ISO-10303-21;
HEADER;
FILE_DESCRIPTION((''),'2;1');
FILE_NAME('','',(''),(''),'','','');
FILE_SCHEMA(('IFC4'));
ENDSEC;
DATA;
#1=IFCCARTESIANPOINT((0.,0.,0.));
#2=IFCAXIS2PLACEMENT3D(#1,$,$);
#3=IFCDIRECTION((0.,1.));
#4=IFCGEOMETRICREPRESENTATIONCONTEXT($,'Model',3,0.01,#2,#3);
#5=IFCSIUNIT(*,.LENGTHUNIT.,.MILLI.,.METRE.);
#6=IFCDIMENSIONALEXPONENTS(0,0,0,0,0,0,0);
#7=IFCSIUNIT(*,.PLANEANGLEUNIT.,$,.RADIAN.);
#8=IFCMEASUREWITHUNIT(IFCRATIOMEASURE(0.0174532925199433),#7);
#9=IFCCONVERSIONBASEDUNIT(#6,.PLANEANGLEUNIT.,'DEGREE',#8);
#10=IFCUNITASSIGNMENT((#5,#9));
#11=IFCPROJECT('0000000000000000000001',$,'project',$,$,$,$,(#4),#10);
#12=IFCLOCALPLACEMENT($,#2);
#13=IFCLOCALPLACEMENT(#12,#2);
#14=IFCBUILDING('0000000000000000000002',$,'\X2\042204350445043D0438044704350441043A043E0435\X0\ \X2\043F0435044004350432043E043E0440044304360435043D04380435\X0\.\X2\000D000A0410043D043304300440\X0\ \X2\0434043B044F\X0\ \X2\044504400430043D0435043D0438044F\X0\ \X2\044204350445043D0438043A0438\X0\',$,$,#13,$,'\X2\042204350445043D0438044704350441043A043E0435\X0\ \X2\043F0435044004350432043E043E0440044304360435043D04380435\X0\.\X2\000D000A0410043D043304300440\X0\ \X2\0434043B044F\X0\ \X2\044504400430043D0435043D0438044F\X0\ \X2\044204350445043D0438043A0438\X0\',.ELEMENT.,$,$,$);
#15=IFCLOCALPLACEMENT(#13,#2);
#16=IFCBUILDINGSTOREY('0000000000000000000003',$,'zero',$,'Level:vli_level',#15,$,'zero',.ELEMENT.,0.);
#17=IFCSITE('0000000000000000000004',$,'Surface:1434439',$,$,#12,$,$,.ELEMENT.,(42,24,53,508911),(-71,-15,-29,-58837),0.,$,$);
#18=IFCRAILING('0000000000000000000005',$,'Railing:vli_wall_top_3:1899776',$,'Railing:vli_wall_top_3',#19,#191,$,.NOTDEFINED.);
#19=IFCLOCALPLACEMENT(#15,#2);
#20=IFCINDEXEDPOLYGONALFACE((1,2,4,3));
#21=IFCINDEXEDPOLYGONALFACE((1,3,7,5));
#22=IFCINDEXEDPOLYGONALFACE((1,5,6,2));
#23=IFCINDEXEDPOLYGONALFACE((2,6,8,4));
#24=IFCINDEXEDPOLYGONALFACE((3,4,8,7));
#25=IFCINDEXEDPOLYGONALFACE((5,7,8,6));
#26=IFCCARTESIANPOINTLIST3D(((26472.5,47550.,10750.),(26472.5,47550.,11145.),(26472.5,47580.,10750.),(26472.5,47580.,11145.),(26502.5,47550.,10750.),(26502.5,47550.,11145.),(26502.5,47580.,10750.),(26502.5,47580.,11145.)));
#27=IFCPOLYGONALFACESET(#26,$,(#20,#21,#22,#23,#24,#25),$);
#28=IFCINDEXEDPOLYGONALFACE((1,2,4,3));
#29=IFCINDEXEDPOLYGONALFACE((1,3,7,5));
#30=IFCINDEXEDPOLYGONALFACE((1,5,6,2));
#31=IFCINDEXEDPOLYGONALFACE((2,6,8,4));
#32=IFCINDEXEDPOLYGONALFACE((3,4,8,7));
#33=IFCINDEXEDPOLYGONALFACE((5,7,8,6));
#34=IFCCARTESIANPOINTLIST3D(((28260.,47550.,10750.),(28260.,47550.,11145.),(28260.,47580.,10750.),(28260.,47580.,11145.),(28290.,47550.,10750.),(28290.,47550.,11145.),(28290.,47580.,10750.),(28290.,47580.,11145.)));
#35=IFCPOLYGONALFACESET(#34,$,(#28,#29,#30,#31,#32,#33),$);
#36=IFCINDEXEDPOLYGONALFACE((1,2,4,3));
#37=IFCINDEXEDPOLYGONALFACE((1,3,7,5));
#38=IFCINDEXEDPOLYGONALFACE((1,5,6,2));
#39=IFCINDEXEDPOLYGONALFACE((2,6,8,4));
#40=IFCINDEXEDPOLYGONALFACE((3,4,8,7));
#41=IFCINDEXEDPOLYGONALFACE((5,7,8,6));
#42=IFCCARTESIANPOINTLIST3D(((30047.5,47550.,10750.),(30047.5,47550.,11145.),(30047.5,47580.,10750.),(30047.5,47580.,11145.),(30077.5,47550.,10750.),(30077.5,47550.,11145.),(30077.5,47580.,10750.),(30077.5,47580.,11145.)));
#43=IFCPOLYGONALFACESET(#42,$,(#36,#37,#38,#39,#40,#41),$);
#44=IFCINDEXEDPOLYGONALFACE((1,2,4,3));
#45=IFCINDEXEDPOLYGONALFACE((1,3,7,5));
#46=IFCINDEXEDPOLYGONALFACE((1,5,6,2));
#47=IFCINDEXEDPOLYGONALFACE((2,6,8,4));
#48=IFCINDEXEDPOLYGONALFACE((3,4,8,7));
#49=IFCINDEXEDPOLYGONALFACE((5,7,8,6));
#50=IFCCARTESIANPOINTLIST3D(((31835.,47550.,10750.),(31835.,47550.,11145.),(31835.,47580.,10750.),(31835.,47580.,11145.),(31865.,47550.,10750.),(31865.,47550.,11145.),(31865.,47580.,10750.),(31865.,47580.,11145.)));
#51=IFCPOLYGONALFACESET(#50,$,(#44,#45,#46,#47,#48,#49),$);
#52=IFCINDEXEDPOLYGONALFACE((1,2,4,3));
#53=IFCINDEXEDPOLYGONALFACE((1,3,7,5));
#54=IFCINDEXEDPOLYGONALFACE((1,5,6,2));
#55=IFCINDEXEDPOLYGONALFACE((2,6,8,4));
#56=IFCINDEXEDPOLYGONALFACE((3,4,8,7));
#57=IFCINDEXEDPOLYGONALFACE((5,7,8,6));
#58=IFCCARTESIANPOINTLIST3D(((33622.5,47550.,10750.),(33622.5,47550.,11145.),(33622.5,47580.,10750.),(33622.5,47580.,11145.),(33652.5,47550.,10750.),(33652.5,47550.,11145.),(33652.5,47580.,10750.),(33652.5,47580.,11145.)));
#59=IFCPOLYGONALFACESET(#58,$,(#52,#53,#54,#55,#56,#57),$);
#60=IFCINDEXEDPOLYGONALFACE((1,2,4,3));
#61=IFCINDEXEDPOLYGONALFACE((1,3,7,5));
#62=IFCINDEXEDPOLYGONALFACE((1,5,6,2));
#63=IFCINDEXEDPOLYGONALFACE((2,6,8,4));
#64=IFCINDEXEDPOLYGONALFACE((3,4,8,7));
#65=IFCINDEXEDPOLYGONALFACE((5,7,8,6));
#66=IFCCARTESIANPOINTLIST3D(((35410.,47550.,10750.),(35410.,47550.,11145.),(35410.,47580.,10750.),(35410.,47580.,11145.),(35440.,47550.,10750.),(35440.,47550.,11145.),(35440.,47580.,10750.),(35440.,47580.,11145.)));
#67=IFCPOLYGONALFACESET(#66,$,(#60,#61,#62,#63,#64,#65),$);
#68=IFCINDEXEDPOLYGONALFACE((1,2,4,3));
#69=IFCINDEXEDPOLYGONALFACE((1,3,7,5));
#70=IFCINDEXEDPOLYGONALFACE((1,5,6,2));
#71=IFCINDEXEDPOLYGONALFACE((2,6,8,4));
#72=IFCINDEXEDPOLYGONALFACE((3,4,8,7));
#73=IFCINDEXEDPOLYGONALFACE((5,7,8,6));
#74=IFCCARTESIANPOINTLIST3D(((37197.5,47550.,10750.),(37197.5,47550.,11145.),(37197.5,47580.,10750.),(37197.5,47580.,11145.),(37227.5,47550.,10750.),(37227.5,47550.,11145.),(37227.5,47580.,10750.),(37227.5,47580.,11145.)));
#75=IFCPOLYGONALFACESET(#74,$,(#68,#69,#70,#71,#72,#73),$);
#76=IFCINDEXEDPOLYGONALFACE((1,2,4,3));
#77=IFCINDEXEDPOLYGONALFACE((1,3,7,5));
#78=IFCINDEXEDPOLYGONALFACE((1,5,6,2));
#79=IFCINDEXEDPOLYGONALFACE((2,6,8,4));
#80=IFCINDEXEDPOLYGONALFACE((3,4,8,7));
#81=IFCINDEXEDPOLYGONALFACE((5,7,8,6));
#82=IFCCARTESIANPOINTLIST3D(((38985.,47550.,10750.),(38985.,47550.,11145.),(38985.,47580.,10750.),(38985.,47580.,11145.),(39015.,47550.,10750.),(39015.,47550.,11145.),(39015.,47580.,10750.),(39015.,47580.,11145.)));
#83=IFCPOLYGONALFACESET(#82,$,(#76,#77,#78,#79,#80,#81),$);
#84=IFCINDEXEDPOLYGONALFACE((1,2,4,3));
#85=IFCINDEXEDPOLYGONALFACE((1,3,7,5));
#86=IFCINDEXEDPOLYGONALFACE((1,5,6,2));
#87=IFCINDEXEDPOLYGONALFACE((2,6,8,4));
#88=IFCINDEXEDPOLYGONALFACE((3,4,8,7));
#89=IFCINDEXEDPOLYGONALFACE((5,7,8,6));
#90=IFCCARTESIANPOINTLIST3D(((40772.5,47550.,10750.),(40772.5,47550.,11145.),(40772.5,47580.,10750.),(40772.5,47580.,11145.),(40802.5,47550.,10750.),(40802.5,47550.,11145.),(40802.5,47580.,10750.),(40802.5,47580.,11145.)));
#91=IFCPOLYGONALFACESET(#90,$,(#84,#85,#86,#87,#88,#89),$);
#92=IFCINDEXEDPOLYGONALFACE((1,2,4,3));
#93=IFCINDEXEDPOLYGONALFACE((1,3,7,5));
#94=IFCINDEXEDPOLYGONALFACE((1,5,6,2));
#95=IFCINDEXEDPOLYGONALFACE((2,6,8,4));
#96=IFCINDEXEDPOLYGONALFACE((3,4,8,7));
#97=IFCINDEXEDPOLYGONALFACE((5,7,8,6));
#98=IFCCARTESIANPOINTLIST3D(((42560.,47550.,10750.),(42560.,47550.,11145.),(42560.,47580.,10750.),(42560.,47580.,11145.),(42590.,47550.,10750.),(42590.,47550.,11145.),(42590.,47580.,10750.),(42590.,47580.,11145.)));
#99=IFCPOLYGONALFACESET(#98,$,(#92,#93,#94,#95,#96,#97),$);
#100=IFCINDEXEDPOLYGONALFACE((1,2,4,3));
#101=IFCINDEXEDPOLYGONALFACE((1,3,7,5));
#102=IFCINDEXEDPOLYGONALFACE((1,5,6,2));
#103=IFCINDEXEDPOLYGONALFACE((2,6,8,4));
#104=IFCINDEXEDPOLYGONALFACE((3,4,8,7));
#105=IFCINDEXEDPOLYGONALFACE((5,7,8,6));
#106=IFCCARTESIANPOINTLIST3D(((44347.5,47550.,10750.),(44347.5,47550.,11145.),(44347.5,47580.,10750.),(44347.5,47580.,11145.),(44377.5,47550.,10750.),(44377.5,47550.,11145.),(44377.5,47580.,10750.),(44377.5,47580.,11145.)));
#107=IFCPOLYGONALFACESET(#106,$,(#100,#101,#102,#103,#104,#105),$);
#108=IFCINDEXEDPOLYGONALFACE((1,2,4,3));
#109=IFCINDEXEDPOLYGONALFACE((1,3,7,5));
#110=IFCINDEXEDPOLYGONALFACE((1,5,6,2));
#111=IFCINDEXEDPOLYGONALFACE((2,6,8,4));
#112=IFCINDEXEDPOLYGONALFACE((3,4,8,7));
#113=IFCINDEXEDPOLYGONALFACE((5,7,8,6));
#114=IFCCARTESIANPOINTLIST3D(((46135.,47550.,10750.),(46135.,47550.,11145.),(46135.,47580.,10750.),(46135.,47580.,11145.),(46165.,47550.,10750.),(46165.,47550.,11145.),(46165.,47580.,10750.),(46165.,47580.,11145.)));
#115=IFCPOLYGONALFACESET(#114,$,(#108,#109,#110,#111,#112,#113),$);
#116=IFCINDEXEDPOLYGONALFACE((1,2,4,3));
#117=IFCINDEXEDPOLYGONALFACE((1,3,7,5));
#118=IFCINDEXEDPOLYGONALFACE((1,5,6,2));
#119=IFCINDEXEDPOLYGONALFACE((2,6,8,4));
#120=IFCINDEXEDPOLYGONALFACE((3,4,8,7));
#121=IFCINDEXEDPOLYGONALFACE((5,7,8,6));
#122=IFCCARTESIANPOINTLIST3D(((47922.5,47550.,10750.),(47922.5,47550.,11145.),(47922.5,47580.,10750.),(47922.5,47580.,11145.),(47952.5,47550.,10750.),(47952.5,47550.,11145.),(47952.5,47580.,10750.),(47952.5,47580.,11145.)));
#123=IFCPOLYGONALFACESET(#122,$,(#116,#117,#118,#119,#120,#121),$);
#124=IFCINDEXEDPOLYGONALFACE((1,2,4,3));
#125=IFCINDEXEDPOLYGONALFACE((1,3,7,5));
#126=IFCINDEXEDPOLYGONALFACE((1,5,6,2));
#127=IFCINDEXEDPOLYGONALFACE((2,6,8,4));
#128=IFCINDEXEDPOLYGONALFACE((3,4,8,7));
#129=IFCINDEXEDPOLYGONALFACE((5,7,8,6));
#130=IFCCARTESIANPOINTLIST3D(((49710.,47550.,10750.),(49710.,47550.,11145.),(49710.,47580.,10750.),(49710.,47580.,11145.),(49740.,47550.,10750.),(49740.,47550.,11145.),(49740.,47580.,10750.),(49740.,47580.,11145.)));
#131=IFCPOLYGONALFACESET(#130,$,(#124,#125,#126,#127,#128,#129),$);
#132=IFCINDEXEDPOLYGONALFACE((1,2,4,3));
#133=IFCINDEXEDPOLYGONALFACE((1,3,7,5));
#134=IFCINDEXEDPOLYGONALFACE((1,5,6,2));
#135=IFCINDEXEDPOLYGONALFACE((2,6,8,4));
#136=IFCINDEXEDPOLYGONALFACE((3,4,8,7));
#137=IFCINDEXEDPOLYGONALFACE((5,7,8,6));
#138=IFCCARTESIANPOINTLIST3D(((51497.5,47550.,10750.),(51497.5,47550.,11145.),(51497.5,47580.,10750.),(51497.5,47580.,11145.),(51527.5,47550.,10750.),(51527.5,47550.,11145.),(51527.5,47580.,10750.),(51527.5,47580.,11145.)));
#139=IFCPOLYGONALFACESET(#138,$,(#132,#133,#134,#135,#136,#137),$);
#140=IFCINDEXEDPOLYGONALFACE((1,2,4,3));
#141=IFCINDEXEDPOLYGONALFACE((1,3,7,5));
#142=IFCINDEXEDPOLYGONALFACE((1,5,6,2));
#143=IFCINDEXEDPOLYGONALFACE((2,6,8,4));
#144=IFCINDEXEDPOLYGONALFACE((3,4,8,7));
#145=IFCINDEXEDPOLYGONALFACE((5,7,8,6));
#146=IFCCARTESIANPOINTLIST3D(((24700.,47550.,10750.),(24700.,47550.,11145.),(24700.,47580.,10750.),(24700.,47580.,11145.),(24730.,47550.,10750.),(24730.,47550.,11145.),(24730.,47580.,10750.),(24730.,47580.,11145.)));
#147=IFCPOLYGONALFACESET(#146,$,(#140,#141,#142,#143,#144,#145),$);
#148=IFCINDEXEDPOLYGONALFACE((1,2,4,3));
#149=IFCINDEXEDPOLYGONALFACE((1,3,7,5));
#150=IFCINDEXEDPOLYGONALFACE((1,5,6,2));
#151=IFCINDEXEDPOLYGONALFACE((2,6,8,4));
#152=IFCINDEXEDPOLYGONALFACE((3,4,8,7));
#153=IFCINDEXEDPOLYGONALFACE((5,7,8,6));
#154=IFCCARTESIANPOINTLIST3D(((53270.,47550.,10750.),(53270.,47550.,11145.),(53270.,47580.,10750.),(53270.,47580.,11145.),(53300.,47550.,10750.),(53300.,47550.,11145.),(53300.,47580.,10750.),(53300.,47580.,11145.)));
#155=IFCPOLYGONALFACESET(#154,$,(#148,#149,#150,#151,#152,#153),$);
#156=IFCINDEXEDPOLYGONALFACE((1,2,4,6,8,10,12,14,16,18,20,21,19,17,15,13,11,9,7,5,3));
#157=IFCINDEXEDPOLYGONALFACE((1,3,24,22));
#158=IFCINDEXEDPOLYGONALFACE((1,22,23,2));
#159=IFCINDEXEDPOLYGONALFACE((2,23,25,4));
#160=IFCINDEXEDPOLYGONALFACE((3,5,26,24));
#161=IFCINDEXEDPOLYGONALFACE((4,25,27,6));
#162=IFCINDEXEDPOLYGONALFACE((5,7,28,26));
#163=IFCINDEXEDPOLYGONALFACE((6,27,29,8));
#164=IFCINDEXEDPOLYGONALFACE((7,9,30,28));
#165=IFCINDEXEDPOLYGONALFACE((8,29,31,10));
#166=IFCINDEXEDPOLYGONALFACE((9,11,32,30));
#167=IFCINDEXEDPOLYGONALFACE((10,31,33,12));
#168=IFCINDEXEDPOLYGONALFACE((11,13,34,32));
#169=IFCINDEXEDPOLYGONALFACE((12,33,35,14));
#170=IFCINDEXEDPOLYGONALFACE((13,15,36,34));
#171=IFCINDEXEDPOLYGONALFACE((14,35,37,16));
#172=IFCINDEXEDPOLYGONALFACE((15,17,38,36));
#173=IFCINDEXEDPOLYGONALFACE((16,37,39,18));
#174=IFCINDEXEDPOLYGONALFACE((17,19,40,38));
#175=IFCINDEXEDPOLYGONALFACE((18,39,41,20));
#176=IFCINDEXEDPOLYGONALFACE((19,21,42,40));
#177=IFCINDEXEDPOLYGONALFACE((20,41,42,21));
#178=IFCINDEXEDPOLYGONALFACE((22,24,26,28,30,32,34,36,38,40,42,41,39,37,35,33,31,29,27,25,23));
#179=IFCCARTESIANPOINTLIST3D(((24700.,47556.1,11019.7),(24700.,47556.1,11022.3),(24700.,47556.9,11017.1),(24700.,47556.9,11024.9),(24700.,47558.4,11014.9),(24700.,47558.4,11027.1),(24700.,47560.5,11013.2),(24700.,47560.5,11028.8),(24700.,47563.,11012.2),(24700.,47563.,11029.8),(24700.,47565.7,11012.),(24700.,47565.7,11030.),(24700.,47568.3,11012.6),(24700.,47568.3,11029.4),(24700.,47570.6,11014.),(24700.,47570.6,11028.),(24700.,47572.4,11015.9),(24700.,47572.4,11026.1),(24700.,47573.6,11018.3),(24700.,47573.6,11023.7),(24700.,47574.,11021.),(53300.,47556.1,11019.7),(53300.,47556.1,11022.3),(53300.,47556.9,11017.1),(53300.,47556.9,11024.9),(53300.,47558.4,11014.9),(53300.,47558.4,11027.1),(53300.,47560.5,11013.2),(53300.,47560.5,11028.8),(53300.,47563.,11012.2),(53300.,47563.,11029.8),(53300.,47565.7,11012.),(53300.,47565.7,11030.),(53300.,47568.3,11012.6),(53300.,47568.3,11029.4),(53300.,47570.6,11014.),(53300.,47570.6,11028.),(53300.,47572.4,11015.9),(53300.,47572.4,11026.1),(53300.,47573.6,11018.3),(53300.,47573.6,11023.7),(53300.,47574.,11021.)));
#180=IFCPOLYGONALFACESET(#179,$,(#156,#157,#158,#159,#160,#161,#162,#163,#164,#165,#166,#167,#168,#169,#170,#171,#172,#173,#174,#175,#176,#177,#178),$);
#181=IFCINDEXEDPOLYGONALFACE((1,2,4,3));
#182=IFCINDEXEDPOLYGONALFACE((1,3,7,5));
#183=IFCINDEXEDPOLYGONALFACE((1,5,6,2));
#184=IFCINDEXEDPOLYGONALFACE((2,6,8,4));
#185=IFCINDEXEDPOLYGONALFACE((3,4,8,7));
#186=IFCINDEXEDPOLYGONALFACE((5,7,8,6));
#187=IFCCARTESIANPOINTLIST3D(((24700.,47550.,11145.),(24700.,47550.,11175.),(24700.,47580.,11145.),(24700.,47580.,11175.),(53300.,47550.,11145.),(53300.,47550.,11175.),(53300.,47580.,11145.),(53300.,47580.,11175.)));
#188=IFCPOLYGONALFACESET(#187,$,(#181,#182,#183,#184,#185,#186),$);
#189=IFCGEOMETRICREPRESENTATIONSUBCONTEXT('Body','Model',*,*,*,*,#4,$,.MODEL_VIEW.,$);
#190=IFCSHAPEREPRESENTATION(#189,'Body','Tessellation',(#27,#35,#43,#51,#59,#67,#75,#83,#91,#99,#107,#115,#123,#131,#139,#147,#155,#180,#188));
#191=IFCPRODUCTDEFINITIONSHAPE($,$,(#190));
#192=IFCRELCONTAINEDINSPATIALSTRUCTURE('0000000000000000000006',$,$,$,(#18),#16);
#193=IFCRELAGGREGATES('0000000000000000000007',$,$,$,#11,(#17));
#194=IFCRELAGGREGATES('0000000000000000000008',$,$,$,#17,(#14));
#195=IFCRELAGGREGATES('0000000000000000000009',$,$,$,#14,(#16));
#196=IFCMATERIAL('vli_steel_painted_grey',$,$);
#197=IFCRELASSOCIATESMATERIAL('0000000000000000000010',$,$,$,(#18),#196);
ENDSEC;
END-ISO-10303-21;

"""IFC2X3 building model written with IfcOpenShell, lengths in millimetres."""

from ifc_helpers import new_model, entity, si_unit, converted_unit, direction, frame, frame_2d, origin, origin_2d_with_axis, place, context, subcontext, project, spatial, rectangle, circle, extrude, material, element, save


model = new_model("IFC2X3")

# Units and contexts
model_context = context("Model", 3, precision=0.01, world=origin(), true_north=direction((0.0, 1.0)))
body_context = subcontext(model_context, "Body", "Model", "MODEL_VIEW")
ifc_project = project(units=[si_unit("LENGTHUNIT", "METRE", prefix="MILLI"), converted_unit("PLANEANGLEUNIT", "DEGREE", entity("IfcRatioMeasure", 0.0174532925199433), si_unit("PLANEANGLEUNIT", "RADIAN"), dimensions=[0, 0, 0, 0, 0, 0, 0])], contexts=[model_context])

# Site, building, storey
site_placement = place(None, origin())
site = spatial("IfcSite", under=ifc_project, at=site_placement, Name="Surface:1434439", CompositionType="ELEMENT", RefLatitude=(42, 24, 53, 508911), RefLongitude=(-71, -15, -29, -58837), RefElevation=0.0)
building_placement = place(site_placement, origin())
building = spatial("IfcBuilding", under=site, at=building_placement, Name="Техническое перевооружение.\r\nАнгар для хранения техники", LongName="Техническое перевооружение.\r\nАнгар для хранения техники", CompositionType="ELEMENT")
storey_placement = place(building_placement, origin())
storey = spatial("IfcBuildingStorey", under=building, at=storey_placement, Name="zero", ObjectType="Level:vli_level", LongName="zero", CompositionType="ELEMENT", Elevation=0.0)

# Railing
ifc_material_1 = material(Name="vli_steel_painted_grey")
railing_placement = place(storey_placement, origin())
element("IfcRailing", 1, at=railing_placement, inside=storey, material=ifc_material_1, Name="Railing:vli_wall_top_3:1899776", ObjectType="Railing:vli_wall_top_3", PredefinedType="NOTDEFINED", context=body_context, shape_type="SweptSolid", body=[
    extrude(rectangle(XDim=30.0, YDim=30.0, at=origin_2d_with_axis()), frame((26487.5, 47565.0, 10750.0), z_axis=(0.0, 0.0, 1.0), x_axis=(0.0, 1.0, 0.0)), (0.0, 0.0, 1.0), 395.0),
    extrude(rectangle(XDim=30.0, YDim=30.0, at=origin_2d_with_axis()), frame((28275.0, 47565.0, 10750.0), z_axis=(0.0, 0.0, 1.0), x_axis=(0.0, 1.0, 0.0)), (0.0, 0.0, 1.0), 395.0),
    extrude(rectangle(XDim=30.0, YDim=30.0, at=origin_2d_with_axis()), frame((30062.5, 47565.0, 10750.0), z_axis=(0.0, 0.0, 1.0), x_axis=(0.0, 1.0, 0.0)), (0.0, 0.0, 1.0), 395.0),
    extrude(rectangle(XDim=30.0, YDim=30.0, at=origin_2d_with_axis()), frame((31850.0, 47565.0, 10750.0), z_axis=(0.0, 0.0, 1.0), x_axis=(0.0, 1.0, 0.0)), (0.0, 0.0, 1.0), 395.0),
    extrude(rectangle(XDim=30.0, YDim=30.0, at=frame_2d((0.0, 0.0), x_axis=(1.0, 0.0))), frame((33637.5, 47565.0, 10750.0), z_axis=(0.0, 0.0, 1.0), x_axis=(0.0, 1.0, 0.0)), (0.0, 0.0, 1.0), 395.0),
    extrude(rectangle(XDim=30.0, YDim=30.0, at=origin_2d_with_axis()), frame((35425.0, 47565.0, 10750.0), z_axis=(0.0, 0.0, 1.0), x_axis=(0.0, 1.0, 0.0)), (0.0, 0.0, 1.0), 395.0),
    extrude(rectangle(XDim=30.0, YDim=30.0, at=origin_2d_with_axis()), frame((37212.5, 47565.0, 10750.0), z_axis=(0.0, 0.0, 1.0), x_axis=(0.0, 1.0, 0.0)), (0.0, 0.0, 1.0), 395.0),
    extrude(rectangle(XDim=30.0, YDim=30.0, at=frame_2d((0.0, 0.0), x_axis=(1.0, 0.0))), frame((39000.0, 47565.0, 10750.0), z_axis=(0.0, 0.0, 1.0), x_axis=(0.0, 1.0, 0.0)), (0.0, 0.0, 1.0), 395.0),
    extrude(rectangle(XDim=30.0, YDim=30.0, at=frame_2d((0.0, 0.0), x_axis=(1.0, 0.0))), frame((40787.5, 47565.0, 10750.0), z_axis=(0.0, 0.0, 1.0), x_axis=(0.0, 1.0, 0.0)), (0.0, 0.0, 1.0), 395.0),
    extrude(rectangle(XDim=30.0, YDim=30.0, at=frame_2d((0.0, 0.0), x_axis=(1.0, 0.0))), frame((42575.0, 47565.0, 10750.0), z_axis=(0.0, 0.0, 1.0), x_axis=(0.0, 1.0, 0.0)), (0.0, 0.0, 1.0), 395.0),
    extrude(rectangle(XDim=30.0, YDim=30.0, at=frame_2d((0.0, 0.0), x_axis=(1.0, 0.0))), frame((44362.5, 47565.0, 10750.0), z_axis=(0.0, 0.0, 1.0), x_axis=(0.0, 1.0, 0.0)), (0.0, 0.0, 1.0), 395.0),
    extrude(rectangle(XDim=30.0, YDim=30.0, at=frame_2d((0.0, 0.0), x_axis=(1.0, 0.0))), frame((46150.0, 47565.0, 10750.0), z_axis=(0.0, 0.0, 1.0), x_axis=(0.0, 1.0, 0.0)), (0.0, 0.0, 1.0), 395.0),
    extrude(rectangle(XDim=30.0, YDim=30.0, at=frame_2d((0.0, 0.0), x_axis=(1.0, 0.0))), frame((47937.5, 47565.0, 10750.0), z_axis=(0.0, 0.0, 1.0), x_axis=(0.0, 1.0, 0.0)), (0.0, 0.0, 1.0), 395.0),
    extrude(rectangle(XDim=30.0, YDim=30.0, at=frame_2d((0.0, 0.0), x_axis=(1.0, 0.0))), frame((49725.0, 47565.0, 10750.0), z_axis=(0.0, 0.0, 1.0), x_axis=(0.0, 1.0, 0.0)), (0.0, 0.0, 1.0), 395.0),
    extrude(rectangle(XDim=30.0, YDim=30.0, at=frame_2d((0.0, 0.0), x_axis=(1.0, 0.0))), frame((51512.5, 47565.0, 10750.0), z_axis=(0.0, 0.0, 1.0), x_axis=(0.0, 1.0, 0.0)), (0.0, 0.0, 1.0), 395.0),
    extrude(rectangle(XDim=30.0, YDim=30.0, at=origin_2d_with_axis()), frame((24715.0, 47565.0, 10750.0), z_axis=(0.0, 0.0, 1.0), x_axis=(0.0, 1.0, 0.0)), (0.0, 0.0, 1.0), 395.0),
    extrude(rectangle(XDim=30.0, YDim=30.0, at=frame_2d((0.0, 0.0), x_axis=(1.0, 0.0))), frame((53285.0, 47565.0, 10750.0), z_axis=(0.0, 0.0, 1.0), x_axis=(0.0, 1.0, 0.0)), (0.0, 0.0, 1.0), 395.0),
    extrude(circle(Radius=9.0, at=origin_2d_with_axis()), frame((24700.0, 47565.0, 11021.0), z_axis=(1.0, 0.0, 0.0), x_axis=(0.0, 1.0, 0.0)), (0.0, 0.0, 1.0), 28600.0),
    extrude(rectangle(XDim=28600.0, YDim=30.0, at=frame_2d((0.0, 0.0), x_axis=(1.0, 0.0))), frame((39000.0, 47565.0, 11145.0), z_axis=(0.0, 0.0, 1.0), x_axis=(-1.0, 0.0, 0.0)), (0.0, 0.0, 1.0), 30.0),
])

save(model, "model.ifc")
